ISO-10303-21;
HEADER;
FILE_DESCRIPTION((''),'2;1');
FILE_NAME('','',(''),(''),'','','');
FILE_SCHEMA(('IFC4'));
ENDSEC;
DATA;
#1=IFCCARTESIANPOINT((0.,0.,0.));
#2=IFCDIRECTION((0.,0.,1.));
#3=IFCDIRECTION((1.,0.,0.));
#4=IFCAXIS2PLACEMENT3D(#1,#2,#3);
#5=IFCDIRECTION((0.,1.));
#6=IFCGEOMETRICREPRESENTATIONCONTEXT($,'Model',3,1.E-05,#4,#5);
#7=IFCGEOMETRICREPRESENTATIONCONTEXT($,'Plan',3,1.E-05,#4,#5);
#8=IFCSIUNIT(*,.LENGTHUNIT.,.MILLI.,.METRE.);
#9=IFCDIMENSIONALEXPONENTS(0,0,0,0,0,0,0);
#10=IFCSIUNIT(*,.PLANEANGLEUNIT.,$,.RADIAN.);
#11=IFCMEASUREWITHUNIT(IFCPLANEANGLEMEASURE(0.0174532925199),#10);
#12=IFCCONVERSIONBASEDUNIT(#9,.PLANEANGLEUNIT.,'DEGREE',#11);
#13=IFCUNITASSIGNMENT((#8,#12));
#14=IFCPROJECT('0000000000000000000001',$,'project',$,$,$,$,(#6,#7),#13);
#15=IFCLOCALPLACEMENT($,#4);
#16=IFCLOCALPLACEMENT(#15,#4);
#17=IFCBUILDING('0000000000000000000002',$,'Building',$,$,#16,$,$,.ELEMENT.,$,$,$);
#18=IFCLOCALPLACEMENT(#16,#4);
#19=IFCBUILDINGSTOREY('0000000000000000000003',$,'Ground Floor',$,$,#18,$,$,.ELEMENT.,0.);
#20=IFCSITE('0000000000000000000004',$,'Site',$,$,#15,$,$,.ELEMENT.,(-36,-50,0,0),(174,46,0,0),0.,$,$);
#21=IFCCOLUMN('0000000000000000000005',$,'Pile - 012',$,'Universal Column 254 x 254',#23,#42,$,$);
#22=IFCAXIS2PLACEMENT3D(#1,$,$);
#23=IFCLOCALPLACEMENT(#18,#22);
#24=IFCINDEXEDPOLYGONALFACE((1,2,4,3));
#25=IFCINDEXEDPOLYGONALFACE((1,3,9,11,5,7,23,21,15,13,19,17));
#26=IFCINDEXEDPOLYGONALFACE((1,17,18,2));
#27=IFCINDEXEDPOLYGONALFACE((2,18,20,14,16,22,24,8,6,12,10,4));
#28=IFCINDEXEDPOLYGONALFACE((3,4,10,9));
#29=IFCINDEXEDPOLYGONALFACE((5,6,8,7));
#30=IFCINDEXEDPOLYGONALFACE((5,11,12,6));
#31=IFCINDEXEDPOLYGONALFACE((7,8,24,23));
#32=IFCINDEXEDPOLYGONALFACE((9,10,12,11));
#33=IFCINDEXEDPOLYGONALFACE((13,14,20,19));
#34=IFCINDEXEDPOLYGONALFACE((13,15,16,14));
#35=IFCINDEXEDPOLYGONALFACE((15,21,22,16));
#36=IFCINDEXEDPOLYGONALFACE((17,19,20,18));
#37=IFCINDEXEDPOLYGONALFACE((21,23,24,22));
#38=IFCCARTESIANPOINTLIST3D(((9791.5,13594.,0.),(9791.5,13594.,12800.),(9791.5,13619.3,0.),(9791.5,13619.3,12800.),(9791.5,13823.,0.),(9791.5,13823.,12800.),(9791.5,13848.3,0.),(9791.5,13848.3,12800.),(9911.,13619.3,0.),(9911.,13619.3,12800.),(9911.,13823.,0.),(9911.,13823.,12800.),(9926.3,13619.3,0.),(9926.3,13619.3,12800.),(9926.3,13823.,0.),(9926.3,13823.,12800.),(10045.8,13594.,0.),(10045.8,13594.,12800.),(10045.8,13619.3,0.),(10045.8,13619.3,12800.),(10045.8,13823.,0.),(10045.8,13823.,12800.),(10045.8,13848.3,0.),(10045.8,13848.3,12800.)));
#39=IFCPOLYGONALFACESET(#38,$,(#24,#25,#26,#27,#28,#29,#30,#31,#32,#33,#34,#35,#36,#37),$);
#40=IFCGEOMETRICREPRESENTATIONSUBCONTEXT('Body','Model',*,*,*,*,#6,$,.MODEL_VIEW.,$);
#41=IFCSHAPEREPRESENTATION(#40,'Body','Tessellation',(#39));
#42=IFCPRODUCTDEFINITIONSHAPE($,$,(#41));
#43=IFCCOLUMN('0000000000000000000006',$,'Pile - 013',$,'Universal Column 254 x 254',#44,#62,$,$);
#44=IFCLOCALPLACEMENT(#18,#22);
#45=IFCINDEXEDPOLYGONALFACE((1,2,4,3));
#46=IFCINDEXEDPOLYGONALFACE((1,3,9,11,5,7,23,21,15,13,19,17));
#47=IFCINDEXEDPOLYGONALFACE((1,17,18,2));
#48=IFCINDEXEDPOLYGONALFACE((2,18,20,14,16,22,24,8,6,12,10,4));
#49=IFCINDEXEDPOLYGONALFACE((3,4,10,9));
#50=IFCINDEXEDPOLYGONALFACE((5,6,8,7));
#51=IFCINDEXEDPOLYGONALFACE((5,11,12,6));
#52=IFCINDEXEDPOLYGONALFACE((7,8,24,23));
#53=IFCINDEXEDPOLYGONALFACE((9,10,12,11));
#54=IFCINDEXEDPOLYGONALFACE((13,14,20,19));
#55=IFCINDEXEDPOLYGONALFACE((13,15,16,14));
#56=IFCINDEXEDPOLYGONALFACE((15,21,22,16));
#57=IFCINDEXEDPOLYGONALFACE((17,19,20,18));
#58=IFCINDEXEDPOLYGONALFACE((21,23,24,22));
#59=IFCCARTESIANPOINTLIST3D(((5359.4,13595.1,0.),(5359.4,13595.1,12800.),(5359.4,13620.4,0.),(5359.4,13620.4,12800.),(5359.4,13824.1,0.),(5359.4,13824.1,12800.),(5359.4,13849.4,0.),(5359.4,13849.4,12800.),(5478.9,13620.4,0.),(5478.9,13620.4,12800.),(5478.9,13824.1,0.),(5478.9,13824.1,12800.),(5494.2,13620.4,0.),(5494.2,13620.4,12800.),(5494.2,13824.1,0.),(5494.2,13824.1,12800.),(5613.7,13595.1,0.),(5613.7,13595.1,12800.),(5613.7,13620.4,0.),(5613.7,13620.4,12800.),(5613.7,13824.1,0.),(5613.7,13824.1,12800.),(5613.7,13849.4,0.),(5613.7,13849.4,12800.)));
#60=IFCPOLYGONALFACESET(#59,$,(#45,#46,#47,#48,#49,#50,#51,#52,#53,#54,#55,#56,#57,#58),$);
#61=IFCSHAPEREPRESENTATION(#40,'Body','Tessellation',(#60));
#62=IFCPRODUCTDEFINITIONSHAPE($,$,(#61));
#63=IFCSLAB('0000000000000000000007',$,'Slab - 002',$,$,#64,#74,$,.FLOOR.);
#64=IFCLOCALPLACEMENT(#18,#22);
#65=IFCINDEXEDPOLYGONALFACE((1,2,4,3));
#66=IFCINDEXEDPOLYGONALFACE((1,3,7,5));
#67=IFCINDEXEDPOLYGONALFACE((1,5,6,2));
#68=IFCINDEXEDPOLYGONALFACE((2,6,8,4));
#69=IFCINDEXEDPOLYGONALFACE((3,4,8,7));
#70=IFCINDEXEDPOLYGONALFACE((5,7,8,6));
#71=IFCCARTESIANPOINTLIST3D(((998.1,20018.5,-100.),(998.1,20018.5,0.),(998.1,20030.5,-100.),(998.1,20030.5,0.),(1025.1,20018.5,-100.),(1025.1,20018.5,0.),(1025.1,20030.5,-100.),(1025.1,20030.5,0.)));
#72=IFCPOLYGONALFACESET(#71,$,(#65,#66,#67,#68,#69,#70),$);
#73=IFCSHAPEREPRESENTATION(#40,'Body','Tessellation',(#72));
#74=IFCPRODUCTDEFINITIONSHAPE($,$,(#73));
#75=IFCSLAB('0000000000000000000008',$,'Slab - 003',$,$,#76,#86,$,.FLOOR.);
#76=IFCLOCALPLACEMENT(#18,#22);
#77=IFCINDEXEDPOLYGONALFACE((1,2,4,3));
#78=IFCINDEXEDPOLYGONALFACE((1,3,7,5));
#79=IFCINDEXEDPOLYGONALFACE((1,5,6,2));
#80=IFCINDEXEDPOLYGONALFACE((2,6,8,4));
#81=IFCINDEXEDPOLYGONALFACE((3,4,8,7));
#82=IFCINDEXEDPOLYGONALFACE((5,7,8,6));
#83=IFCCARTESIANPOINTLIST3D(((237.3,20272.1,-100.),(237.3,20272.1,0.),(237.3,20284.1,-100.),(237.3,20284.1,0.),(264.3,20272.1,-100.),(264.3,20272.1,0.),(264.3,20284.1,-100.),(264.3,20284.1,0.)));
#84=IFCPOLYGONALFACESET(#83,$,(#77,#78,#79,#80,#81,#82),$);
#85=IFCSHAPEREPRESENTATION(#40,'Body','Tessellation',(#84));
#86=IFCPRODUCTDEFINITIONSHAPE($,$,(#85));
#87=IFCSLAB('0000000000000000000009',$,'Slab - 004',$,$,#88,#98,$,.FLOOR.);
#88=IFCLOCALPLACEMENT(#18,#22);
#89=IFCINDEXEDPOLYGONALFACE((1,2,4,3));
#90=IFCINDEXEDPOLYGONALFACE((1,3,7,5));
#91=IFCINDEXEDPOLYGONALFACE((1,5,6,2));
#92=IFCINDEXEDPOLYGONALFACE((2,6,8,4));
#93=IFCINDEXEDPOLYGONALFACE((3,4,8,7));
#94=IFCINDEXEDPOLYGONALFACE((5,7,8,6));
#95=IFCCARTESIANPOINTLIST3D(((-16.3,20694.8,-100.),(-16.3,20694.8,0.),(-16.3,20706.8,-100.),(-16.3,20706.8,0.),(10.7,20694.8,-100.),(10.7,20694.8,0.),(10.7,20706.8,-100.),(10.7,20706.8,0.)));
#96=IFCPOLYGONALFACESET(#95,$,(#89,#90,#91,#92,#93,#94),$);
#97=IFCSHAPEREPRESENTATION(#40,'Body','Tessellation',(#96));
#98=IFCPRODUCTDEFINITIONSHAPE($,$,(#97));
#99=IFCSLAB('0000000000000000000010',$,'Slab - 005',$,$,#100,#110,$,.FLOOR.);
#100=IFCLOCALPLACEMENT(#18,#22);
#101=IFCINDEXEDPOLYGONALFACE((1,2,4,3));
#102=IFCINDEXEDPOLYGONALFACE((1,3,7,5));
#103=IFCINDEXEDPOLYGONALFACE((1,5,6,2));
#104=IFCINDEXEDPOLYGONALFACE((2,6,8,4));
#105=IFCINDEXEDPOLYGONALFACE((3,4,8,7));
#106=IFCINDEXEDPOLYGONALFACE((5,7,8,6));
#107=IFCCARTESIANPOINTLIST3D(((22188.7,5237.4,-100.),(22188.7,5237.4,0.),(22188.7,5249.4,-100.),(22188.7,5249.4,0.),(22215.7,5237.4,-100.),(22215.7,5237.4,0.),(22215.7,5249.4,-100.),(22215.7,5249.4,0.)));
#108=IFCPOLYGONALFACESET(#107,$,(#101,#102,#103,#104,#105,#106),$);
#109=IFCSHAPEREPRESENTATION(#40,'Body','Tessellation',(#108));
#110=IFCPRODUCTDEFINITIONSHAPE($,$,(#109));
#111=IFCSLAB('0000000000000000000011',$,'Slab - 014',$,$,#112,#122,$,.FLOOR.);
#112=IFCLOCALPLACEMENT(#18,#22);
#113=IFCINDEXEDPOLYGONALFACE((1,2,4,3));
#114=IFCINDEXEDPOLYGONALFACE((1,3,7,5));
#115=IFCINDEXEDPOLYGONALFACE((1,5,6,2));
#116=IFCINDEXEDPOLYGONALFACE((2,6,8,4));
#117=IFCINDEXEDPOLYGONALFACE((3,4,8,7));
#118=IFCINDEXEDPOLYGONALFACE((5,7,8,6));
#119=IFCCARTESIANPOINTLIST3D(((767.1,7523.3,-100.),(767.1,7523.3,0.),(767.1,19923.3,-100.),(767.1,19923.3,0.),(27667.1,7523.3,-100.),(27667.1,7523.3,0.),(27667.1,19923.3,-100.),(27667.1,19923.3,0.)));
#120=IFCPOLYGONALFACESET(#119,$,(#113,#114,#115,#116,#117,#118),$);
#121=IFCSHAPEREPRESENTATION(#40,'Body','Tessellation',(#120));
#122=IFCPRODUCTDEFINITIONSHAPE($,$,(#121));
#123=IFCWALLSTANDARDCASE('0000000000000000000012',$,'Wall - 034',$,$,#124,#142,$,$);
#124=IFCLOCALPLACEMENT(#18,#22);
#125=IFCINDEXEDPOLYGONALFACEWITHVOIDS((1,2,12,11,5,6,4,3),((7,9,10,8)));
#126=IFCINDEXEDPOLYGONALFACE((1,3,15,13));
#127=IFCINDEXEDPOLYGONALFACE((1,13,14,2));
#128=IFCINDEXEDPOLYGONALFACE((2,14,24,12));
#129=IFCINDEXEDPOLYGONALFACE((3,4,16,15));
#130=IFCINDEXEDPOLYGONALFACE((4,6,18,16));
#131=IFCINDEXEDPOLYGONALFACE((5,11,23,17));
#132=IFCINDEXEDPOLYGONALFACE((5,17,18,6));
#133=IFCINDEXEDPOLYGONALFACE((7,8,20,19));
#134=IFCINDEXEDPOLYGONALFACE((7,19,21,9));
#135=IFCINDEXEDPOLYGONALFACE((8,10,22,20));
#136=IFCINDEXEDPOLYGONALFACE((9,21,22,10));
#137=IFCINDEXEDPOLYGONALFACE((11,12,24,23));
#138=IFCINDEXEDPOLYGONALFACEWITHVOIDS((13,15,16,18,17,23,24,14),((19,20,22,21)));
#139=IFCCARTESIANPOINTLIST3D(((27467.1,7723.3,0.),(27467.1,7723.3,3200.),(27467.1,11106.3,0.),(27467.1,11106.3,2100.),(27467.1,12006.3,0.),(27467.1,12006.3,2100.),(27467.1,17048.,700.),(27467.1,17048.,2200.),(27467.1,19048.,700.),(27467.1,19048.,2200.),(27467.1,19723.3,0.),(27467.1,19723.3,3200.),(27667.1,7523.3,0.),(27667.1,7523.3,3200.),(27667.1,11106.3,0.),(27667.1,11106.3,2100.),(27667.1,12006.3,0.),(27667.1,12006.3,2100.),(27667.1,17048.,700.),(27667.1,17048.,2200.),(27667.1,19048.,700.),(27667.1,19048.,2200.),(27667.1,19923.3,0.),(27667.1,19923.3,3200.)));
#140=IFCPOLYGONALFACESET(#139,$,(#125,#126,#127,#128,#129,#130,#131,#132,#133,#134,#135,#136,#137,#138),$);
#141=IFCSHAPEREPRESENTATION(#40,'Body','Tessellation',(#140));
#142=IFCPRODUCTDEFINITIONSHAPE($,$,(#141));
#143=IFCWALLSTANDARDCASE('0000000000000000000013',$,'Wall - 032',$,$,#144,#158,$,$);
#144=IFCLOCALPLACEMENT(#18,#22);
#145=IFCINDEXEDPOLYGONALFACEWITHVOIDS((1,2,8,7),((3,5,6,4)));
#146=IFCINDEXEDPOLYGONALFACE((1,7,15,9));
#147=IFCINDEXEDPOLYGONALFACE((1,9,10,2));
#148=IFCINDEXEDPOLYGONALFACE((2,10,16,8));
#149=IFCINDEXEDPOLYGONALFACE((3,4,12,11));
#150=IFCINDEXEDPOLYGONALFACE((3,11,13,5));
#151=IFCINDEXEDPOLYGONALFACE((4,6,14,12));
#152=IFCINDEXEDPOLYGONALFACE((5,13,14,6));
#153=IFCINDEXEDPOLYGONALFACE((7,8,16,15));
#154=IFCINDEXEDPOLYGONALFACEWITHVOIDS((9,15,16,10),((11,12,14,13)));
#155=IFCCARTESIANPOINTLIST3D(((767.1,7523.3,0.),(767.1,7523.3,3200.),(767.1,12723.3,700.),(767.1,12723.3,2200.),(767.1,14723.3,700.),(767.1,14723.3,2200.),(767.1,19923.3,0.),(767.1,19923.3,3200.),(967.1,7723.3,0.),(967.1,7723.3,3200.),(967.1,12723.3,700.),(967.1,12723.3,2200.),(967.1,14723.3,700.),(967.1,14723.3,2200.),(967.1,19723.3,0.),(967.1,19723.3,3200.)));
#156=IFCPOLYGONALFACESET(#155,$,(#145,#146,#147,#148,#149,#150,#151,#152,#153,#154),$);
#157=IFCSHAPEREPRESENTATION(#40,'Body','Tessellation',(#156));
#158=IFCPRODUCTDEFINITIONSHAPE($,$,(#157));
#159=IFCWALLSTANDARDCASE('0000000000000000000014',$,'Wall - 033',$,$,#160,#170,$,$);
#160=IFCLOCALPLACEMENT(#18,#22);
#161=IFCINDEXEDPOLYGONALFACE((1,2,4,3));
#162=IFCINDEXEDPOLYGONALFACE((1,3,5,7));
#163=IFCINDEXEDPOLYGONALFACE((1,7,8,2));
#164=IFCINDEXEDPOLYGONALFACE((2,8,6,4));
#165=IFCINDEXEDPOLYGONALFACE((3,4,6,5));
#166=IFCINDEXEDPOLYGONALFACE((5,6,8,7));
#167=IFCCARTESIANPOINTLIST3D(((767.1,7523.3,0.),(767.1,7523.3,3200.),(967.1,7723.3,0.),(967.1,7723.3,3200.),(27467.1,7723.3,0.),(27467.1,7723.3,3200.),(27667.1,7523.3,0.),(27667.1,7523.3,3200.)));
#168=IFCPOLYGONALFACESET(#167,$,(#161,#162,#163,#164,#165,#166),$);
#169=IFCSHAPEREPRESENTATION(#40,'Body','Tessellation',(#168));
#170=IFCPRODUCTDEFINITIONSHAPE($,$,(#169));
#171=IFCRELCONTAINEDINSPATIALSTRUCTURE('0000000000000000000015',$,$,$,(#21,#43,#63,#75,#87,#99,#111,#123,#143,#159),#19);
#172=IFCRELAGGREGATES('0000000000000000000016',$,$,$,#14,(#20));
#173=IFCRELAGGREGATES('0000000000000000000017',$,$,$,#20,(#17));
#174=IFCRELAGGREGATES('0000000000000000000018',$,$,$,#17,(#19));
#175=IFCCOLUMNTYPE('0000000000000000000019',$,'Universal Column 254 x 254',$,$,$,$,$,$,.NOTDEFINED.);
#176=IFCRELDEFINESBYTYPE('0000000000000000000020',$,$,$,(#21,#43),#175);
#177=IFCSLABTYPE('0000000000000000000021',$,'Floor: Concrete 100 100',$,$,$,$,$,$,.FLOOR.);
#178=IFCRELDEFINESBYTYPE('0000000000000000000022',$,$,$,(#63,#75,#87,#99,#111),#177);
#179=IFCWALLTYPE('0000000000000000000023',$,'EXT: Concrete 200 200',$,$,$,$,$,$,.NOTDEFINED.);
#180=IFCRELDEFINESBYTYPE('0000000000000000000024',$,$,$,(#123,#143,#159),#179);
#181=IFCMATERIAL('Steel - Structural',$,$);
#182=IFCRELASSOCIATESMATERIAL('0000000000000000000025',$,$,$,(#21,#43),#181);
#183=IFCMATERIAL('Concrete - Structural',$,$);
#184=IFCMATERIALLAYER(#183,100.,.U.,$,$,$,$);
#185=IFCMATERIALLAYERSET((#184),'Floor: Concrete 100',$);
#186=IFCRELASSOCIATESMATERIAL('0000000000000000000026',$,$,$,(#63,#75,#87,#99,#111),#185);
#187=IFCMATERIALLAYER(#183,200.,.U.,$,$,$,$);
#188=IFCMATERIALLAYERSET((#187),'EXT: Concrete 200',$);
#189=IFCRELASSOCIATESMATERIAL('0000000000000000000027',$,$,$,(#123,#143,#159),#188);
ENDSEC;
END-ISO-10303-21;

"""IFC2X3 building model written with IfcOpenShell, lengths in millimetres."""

from ifc_helpers import new_model, entity, si_unit, converted_unit, direction, frame, origin_with_axes, origin_2d_with_axis, place, context, subcontext, project, spatial, polyline, rectangle, outline, extrude, material, layer, layer_set, layer_usage, type_object, element, save


model = new_model("IFC2X3")

# Units and contexts
model_context = context("Model", 3, precision=1e-05, world=origin_with_axes(), true_north=direction((0.0, 1.0)))
plan_context = context("Plan", 3, precision=1e-05, world=origin_with_axes(), true_north=direction((0.0, 1.0)))
body_context = subcontext(model_context, "Body", "Model", "MODEL_VIEW")
ifc_project = project(units=[si_unit("LENGTHUNIT", "METRE", prefix="MILLI"), converted_unit("PLANEANGLEUNIT", "DEGREE", entity("IfcPlaneAngleMeasure", 0.0174532925199), si_unit("PLANEANGLEUNIT", "RADIAN"), dimensions=[0, 0, 0, 0, 0, 0, 0])], contexts=[model_context, plan_context])

# Site, building, storey
site_placement = place(None, origin_with_axes())
site = spatial("IfcSite", under=ifc_project, at=site_placement, Name="Site", CompositionType="ELEMENT", RefLatitude=(-36, -50, 0, 0), RefLongitude=(174, 46, 0, 0), RefElevation=0.0)
building_placement = place(site_placement, origin_with_axes())
building = spatial("IfcBuilding", under=site, at=building_placement, Name="Building", CompositionType="ELEMENT")
storey_placement = place(building_placement, origin_with_axes())
storey = spatial("IfcBuildingStorey", under=building, at=storey_placement, Name="Ground Floor", CompositionType="ELEMENT", Elevation=0.0)

# Columns
ifc_material_1 = material(Name="Steel - Structural")
column_type = type_object("IfcColumnType", Name="Universal Column 254 x 254", PredefinedType="NOTDEFINED")
for number, where, z_axis, x_axis, name in (
    (1, (9918.6, 13721.1, 0.0), (0.0, 0.0, 1.0), (1.0, 0.0, 0.0), "Pile - 012"),
    (2, (5486.6, 13722.3, 0.0), (0.0, 0.0, 1.0), (1.0, 0.0, 0.0), "Pile - 013"),
):
    element("IfcColumn", number, at=place(storey_placement, frame(where, z_axis=z_axis, x_axis=x_axis)), inside=storey, type_object=column_type, material=ifc_material_1, Name=name, ObjectType="Universal Column 254 x 254", context=body_context, shape_type="SweptSolid", body=[
        extrude(outline(polyline([(-127.2, -127.2), (127.2, -127.2), (127.2, -101.8), (7.7, -101.8), (7.7, 101.8), (127.2, 101.8), (127.2, 127.2), (-127.2, 127.2), (-127.2, 101.8), (-7.7, 101.8), (-7.7, -101.8), (-127.2, -101.8), (-127.2, -127.2)])), origin_with_axes(), (0.0, 0.0, 1.0), 12800.0),
    ])

# Slabs
ifc_material_2 = material(Name="Concrete - Structural")
ifc_layer_1 = layer(ifc_material_2, 100.0, ventilated="UNKNOWN")
ifc_layer_set_1 = layer_set([ifc_layer_1], Name="Floor: Concrete 100")
ifc_layer_usage_1 = layer_usage(ifc_layer_set_1, "AXIS3", "NEGATIVE", 100.0)
slab_type = type_object("IfcSlabType", Name="Floor: Concrete 100 100", PredefinedType="FLOOR")
slab_1_placement = place(storey_placement, frame((998.1, 20030.5, 0.0), z_axis=(0.0, 0.0, 1.0), x_axis=(1.0, 0.0, 0.0)))
element("IfcSlab", 3, at=slab_1_placement, inside=storey, type_object=slab_type, material=ifc_layer_usage_1, Name="Slab - 002", PredefinedType="FLOOR", context=body_context, shape_type="SweptSolid", body=[
    extrude(outline(polyline([(0.0, 0.0), (0.0, -12.0), (27.0, -12.0), (27.0, 0.0), (0.0, 0.0)])), frame((0.0, 0.0, -100.0), z_axis=(0.0, 0.0, 1.0), x_axis=(1.0, 0.0, 0.0)), (0.0, 0.0, 1.0), 100.0),
])
ifc_layer_usage_2 = layer_usage(ifc_layer_set_1, "AXIS3", "NEGATIVE", 100.0)
slab_2_placement = place(storey_placement, frame((237.3, 20284.1, 0.0), z_axis=(0.0, 0.0, 1.0), x_axis=(1.0, 0.0, 0.0)))
element("IfcSlab", 4, at=slab_2_placement, inside=storey, type_object=slab_type, material=ifc_layer_usage_2, Name="Slab - 003", PredefinedType="FLOOR", context=body_context, shape_type="SweptSolid", body=[
    extrude(outline(polyline([(0.0, 0.0), (0.0, -12.0), (27.0, -12.0), (27.0, 0.0), (0.0, 0.0)])), frame((0.0, 0.0, -100.0), z_axis=(0.0, 0.0, 1.0), x_axis=(1.0, 0.0, 0.0)), (0.0, 0.0, 1.0), 100.0),
])
ifc_layer_usage_3 = layer_usage(ifc_layer_set_1, "AXIS3", "NEGATIVE", 100.0)
slab_3_placement = place(storey_placement, frame((-16.3, 20706.8, 0.0), z_axis=(0.0, 0.0, 1.0), x_axis=(1.0, 0.0, 0.0)))
element("IfcSlab", 5, at=slab_3_placement, inside=storey, type_object=slab_type, material=ifc_layer_usage_3, Name="Slab - 004", PredefinedType="FLOOR", context=body_context, shape_type="SweptSolid", body=[
    extrude(outline(polyline([(0.0, 0.0), (0.0, -12.0), (27.0, -12.0), (27.0, 0.0), (0.0, 0.0)])), frame((0.0, 0.0, -100.0), z_axis=(0.0, 0.0, 1.0), x_axis=(1.0, 0.0, 0.0)), (0.0, 0.0, 1.0), 100.0),
])
ifc_layer_usage_4 = layer_usage(ifc_layer_set_1, "AXIS3", "NEGATIVE", 100.0)
slab_4_placement = place(storey_placement, frame((22215.7, 5237.4, 0.0), z_axis=(0.0, 0.0, 1.0), x_axis=(1.0, 0.0, 0.0)))
element("IfcSlab", 6, at=slab_4_placement, inside=storey, type_object=slab_type, material=ifc_layer_usage_4, Name="Slab - 005", PredefinedType="FLOOR", context=body_context, shape_type="SweptSolid", body=[
    extrude(outline(polyline([(0.0, 0.0), (0.0, 12.0), (-27.0, 12.0), (-27.0, 0.0), (0.0, 0.0)])), frame((0.0, 0.0, -100.0), z_axis=(0.0, 0.0, 1.0), x_axis=(1.0, 0.0, 0.0)), (0.0, 0.0, 1.0), 100.0),
])
ifc_layer_usage_5 = layer_usage(ifc_layer_set_1, "AXIS3", "NEGATIVE", 100.0)
slab_5_placement = place(storey_placement, frame((27667.1, 7523.3, 0.0), z_axis=(0.0, 0.0, 1.0), x_axis=(1.0, 0.0, 0.0)))
element("IfcSlab", 7, at=slab_5_placement, inside=storey, type_object=slab_type, material=ifc_layer_usage_5, Name="Slab - 014", PredefinedType="FLOOR", context=body_context, shape_type="SweptSolid", body=[
    extrude(outline(polyline([(0.0, 0.0), (0.0, 12400.0), (-26900.0, 12400.0), (-26900.0, 0.0), (0.0, 0.0)])), frame((0.0, 0.0, -100.0), z_axis=(0.0, 0.0, 1.0), x_axis=(1.0, 0.0, 0.0)), (0.0, 0.0, 1.0), 100.0),
])

# Wall, openings
ifc_layer_2 = layer(ifc_material_2, 200.0, ventilated="UNKNOWN")
ifc_layer_set_2 = layer_set([ifc_layer_2], Name="EXT: Concrete 200")
ifc_layer_usage_6 = layer_usage(ifc_layer_set_2, "AXIS2", "POSITIVE", 0.0)
wall_type_1 = type_object("IfcWallType", Name="EXT: Concrete 200 200", PredefinedType="NOTDEFINED")
wall_1_placement = place(storey_placement, frame((27667.1, 7523.3, 0.0), z_axis=(0.0, 0.0, 1.0), x_axis=(0.0, 1.0, 0.0)))
wall_1 = element("IfcWallStandardCase", 8, at=wall_1_placement, inside=storey, type_object=wall_type_1, material=ifc_layer_usage_6, Name="Wall - 034", context=body_context, shape_type="SweptSolid", body=[
    extrude(outline(polyline([(0.0, 0.0), (12400.0, 0.0), (12200.0, 200.0), (200.0, 200.0), (0.0, 0.0)])), origin_with_axes(), (0.0, 0.0, 1.0), 3200.0),
])
opening_1_placement = place(wall_1_placement, frame((10524.7, 0.0, 700.0), z_axis=(0.0, 0.0, 1.0), x_axis=(1.0, 0.0, 0.0)))
element("IfcOpeningElement", 9, at=opening_1_placement, cuts=wall_1, context=body_context, shape_type="SweptSolid", body=[
    extrude(rectangle(XDim=2000.0, YDim=1500.0, at=origin_2d_with_axis()), frame((0.0, 200.0, 750.0), z_axis=(0.0, 1.0, 0.0), x_axis=(1.0, 0.0, 0.0)), (0.0, 0.0, -1.0), 600.0),
])
opening_2_placement = place(wall_1_placement, frame((4033.0, 0.0, 0.0), z_axis=(0.0, 0.0, 1.0), x_axis=(1.0, 0.0, 0.0)))
element("IfcOpeningElement", 10, at=opening_2_placement, cuts=wall_1, context=body_context, shape_type="SweptSolid", body=[
    extrude(rectangle(XDim=900.0, YDim=2100.0, at=origin_2d_with_axis()), frame((0.0, -200.0, 1050.0), z_axis=(0.0, 1.0, 0.0), x_axis=(-1.0, 0.0, 0.0)), (0.0, 0.0, 1.0), 600.0),
])

# Wall, opening
ifc_layer_usage_7 = layer_usage(ifc_layer_set_2, "AXIS2", "POSITIVE", 0.0)
wall_2_placement = place(storey_placement, frame((767.1, 19923.3, 0.0), z_axis=(0.0, 0.0, 1.0), x_axis=(0.0, -1.0, 0.0)))
wall_2 = element("IfcWallStandardCase", 11, at=wall_2_placement, inside=storey, type_object=wall_type_1, material=ifc_layer_usage_7, Name="Wall - 032", context=body_context, shape_type="SweptSolid", body=[
    extrude(outline(polyline([(0.0, 0.0), (12400.0, 0.0), (12200.0, 200.0), (200.0, 200.0), (0.0, 0.0)])), origin_with_axes(), (0.0, 0.0, 1.0), 3200.0),
])
opening_3_placement = place(wall_2_placement, frame((6200.0, 0.0, 700.0), z_axis=(0.0, 0.0, 1.0), x_axis=(1.0, 0.0, 0.0)))
element("IfcOpeningElement", 12, at=opening_3_placement, cuts=wall_2, context=body_context, shape_type="SweptSolid", body=[
    extrude(rectangle(XDim=2000.0, YDim=1500.0, at=origin_2d_with_axis()), frame((0.0, 200.0, 750.0), z_axis=(0.0, 1.0, 0.0), x_axis=(1.0, 0.0, 0.0)), (0.0, 0.0, -1.0), 600.0),
])

# Wall
ifc_layer_usage_8 = layer_usage(ifc_layer_set_2, "AXIS2", "POSITIVE", 0.0)
wall_3_placement = place(storey_placement, frame((767.1, 7523.3, 0.0), z_axis=(0.0, 0.0, 1.0), x_axis=(1.0, 0.0, 0.0)))
element("IfcWallStandardCase", 13, at=wall_3_placement, inside=storey, type_object=wall_type_1, material=ifc_layer_usage_8, Name="Wall - 033", context=body_context, shape_type="SweptSolid", body=[
    extrude(outline(polyline([(0.0, 0.0), (26900.0, 0.0), (26700.0, 200.0), (200.0, 200.0), (0.0, 0.0)])), origin_with_axes(), (0.0, 0.0, 1.0), 3200.0),
])

save(model, "model.ifc")
